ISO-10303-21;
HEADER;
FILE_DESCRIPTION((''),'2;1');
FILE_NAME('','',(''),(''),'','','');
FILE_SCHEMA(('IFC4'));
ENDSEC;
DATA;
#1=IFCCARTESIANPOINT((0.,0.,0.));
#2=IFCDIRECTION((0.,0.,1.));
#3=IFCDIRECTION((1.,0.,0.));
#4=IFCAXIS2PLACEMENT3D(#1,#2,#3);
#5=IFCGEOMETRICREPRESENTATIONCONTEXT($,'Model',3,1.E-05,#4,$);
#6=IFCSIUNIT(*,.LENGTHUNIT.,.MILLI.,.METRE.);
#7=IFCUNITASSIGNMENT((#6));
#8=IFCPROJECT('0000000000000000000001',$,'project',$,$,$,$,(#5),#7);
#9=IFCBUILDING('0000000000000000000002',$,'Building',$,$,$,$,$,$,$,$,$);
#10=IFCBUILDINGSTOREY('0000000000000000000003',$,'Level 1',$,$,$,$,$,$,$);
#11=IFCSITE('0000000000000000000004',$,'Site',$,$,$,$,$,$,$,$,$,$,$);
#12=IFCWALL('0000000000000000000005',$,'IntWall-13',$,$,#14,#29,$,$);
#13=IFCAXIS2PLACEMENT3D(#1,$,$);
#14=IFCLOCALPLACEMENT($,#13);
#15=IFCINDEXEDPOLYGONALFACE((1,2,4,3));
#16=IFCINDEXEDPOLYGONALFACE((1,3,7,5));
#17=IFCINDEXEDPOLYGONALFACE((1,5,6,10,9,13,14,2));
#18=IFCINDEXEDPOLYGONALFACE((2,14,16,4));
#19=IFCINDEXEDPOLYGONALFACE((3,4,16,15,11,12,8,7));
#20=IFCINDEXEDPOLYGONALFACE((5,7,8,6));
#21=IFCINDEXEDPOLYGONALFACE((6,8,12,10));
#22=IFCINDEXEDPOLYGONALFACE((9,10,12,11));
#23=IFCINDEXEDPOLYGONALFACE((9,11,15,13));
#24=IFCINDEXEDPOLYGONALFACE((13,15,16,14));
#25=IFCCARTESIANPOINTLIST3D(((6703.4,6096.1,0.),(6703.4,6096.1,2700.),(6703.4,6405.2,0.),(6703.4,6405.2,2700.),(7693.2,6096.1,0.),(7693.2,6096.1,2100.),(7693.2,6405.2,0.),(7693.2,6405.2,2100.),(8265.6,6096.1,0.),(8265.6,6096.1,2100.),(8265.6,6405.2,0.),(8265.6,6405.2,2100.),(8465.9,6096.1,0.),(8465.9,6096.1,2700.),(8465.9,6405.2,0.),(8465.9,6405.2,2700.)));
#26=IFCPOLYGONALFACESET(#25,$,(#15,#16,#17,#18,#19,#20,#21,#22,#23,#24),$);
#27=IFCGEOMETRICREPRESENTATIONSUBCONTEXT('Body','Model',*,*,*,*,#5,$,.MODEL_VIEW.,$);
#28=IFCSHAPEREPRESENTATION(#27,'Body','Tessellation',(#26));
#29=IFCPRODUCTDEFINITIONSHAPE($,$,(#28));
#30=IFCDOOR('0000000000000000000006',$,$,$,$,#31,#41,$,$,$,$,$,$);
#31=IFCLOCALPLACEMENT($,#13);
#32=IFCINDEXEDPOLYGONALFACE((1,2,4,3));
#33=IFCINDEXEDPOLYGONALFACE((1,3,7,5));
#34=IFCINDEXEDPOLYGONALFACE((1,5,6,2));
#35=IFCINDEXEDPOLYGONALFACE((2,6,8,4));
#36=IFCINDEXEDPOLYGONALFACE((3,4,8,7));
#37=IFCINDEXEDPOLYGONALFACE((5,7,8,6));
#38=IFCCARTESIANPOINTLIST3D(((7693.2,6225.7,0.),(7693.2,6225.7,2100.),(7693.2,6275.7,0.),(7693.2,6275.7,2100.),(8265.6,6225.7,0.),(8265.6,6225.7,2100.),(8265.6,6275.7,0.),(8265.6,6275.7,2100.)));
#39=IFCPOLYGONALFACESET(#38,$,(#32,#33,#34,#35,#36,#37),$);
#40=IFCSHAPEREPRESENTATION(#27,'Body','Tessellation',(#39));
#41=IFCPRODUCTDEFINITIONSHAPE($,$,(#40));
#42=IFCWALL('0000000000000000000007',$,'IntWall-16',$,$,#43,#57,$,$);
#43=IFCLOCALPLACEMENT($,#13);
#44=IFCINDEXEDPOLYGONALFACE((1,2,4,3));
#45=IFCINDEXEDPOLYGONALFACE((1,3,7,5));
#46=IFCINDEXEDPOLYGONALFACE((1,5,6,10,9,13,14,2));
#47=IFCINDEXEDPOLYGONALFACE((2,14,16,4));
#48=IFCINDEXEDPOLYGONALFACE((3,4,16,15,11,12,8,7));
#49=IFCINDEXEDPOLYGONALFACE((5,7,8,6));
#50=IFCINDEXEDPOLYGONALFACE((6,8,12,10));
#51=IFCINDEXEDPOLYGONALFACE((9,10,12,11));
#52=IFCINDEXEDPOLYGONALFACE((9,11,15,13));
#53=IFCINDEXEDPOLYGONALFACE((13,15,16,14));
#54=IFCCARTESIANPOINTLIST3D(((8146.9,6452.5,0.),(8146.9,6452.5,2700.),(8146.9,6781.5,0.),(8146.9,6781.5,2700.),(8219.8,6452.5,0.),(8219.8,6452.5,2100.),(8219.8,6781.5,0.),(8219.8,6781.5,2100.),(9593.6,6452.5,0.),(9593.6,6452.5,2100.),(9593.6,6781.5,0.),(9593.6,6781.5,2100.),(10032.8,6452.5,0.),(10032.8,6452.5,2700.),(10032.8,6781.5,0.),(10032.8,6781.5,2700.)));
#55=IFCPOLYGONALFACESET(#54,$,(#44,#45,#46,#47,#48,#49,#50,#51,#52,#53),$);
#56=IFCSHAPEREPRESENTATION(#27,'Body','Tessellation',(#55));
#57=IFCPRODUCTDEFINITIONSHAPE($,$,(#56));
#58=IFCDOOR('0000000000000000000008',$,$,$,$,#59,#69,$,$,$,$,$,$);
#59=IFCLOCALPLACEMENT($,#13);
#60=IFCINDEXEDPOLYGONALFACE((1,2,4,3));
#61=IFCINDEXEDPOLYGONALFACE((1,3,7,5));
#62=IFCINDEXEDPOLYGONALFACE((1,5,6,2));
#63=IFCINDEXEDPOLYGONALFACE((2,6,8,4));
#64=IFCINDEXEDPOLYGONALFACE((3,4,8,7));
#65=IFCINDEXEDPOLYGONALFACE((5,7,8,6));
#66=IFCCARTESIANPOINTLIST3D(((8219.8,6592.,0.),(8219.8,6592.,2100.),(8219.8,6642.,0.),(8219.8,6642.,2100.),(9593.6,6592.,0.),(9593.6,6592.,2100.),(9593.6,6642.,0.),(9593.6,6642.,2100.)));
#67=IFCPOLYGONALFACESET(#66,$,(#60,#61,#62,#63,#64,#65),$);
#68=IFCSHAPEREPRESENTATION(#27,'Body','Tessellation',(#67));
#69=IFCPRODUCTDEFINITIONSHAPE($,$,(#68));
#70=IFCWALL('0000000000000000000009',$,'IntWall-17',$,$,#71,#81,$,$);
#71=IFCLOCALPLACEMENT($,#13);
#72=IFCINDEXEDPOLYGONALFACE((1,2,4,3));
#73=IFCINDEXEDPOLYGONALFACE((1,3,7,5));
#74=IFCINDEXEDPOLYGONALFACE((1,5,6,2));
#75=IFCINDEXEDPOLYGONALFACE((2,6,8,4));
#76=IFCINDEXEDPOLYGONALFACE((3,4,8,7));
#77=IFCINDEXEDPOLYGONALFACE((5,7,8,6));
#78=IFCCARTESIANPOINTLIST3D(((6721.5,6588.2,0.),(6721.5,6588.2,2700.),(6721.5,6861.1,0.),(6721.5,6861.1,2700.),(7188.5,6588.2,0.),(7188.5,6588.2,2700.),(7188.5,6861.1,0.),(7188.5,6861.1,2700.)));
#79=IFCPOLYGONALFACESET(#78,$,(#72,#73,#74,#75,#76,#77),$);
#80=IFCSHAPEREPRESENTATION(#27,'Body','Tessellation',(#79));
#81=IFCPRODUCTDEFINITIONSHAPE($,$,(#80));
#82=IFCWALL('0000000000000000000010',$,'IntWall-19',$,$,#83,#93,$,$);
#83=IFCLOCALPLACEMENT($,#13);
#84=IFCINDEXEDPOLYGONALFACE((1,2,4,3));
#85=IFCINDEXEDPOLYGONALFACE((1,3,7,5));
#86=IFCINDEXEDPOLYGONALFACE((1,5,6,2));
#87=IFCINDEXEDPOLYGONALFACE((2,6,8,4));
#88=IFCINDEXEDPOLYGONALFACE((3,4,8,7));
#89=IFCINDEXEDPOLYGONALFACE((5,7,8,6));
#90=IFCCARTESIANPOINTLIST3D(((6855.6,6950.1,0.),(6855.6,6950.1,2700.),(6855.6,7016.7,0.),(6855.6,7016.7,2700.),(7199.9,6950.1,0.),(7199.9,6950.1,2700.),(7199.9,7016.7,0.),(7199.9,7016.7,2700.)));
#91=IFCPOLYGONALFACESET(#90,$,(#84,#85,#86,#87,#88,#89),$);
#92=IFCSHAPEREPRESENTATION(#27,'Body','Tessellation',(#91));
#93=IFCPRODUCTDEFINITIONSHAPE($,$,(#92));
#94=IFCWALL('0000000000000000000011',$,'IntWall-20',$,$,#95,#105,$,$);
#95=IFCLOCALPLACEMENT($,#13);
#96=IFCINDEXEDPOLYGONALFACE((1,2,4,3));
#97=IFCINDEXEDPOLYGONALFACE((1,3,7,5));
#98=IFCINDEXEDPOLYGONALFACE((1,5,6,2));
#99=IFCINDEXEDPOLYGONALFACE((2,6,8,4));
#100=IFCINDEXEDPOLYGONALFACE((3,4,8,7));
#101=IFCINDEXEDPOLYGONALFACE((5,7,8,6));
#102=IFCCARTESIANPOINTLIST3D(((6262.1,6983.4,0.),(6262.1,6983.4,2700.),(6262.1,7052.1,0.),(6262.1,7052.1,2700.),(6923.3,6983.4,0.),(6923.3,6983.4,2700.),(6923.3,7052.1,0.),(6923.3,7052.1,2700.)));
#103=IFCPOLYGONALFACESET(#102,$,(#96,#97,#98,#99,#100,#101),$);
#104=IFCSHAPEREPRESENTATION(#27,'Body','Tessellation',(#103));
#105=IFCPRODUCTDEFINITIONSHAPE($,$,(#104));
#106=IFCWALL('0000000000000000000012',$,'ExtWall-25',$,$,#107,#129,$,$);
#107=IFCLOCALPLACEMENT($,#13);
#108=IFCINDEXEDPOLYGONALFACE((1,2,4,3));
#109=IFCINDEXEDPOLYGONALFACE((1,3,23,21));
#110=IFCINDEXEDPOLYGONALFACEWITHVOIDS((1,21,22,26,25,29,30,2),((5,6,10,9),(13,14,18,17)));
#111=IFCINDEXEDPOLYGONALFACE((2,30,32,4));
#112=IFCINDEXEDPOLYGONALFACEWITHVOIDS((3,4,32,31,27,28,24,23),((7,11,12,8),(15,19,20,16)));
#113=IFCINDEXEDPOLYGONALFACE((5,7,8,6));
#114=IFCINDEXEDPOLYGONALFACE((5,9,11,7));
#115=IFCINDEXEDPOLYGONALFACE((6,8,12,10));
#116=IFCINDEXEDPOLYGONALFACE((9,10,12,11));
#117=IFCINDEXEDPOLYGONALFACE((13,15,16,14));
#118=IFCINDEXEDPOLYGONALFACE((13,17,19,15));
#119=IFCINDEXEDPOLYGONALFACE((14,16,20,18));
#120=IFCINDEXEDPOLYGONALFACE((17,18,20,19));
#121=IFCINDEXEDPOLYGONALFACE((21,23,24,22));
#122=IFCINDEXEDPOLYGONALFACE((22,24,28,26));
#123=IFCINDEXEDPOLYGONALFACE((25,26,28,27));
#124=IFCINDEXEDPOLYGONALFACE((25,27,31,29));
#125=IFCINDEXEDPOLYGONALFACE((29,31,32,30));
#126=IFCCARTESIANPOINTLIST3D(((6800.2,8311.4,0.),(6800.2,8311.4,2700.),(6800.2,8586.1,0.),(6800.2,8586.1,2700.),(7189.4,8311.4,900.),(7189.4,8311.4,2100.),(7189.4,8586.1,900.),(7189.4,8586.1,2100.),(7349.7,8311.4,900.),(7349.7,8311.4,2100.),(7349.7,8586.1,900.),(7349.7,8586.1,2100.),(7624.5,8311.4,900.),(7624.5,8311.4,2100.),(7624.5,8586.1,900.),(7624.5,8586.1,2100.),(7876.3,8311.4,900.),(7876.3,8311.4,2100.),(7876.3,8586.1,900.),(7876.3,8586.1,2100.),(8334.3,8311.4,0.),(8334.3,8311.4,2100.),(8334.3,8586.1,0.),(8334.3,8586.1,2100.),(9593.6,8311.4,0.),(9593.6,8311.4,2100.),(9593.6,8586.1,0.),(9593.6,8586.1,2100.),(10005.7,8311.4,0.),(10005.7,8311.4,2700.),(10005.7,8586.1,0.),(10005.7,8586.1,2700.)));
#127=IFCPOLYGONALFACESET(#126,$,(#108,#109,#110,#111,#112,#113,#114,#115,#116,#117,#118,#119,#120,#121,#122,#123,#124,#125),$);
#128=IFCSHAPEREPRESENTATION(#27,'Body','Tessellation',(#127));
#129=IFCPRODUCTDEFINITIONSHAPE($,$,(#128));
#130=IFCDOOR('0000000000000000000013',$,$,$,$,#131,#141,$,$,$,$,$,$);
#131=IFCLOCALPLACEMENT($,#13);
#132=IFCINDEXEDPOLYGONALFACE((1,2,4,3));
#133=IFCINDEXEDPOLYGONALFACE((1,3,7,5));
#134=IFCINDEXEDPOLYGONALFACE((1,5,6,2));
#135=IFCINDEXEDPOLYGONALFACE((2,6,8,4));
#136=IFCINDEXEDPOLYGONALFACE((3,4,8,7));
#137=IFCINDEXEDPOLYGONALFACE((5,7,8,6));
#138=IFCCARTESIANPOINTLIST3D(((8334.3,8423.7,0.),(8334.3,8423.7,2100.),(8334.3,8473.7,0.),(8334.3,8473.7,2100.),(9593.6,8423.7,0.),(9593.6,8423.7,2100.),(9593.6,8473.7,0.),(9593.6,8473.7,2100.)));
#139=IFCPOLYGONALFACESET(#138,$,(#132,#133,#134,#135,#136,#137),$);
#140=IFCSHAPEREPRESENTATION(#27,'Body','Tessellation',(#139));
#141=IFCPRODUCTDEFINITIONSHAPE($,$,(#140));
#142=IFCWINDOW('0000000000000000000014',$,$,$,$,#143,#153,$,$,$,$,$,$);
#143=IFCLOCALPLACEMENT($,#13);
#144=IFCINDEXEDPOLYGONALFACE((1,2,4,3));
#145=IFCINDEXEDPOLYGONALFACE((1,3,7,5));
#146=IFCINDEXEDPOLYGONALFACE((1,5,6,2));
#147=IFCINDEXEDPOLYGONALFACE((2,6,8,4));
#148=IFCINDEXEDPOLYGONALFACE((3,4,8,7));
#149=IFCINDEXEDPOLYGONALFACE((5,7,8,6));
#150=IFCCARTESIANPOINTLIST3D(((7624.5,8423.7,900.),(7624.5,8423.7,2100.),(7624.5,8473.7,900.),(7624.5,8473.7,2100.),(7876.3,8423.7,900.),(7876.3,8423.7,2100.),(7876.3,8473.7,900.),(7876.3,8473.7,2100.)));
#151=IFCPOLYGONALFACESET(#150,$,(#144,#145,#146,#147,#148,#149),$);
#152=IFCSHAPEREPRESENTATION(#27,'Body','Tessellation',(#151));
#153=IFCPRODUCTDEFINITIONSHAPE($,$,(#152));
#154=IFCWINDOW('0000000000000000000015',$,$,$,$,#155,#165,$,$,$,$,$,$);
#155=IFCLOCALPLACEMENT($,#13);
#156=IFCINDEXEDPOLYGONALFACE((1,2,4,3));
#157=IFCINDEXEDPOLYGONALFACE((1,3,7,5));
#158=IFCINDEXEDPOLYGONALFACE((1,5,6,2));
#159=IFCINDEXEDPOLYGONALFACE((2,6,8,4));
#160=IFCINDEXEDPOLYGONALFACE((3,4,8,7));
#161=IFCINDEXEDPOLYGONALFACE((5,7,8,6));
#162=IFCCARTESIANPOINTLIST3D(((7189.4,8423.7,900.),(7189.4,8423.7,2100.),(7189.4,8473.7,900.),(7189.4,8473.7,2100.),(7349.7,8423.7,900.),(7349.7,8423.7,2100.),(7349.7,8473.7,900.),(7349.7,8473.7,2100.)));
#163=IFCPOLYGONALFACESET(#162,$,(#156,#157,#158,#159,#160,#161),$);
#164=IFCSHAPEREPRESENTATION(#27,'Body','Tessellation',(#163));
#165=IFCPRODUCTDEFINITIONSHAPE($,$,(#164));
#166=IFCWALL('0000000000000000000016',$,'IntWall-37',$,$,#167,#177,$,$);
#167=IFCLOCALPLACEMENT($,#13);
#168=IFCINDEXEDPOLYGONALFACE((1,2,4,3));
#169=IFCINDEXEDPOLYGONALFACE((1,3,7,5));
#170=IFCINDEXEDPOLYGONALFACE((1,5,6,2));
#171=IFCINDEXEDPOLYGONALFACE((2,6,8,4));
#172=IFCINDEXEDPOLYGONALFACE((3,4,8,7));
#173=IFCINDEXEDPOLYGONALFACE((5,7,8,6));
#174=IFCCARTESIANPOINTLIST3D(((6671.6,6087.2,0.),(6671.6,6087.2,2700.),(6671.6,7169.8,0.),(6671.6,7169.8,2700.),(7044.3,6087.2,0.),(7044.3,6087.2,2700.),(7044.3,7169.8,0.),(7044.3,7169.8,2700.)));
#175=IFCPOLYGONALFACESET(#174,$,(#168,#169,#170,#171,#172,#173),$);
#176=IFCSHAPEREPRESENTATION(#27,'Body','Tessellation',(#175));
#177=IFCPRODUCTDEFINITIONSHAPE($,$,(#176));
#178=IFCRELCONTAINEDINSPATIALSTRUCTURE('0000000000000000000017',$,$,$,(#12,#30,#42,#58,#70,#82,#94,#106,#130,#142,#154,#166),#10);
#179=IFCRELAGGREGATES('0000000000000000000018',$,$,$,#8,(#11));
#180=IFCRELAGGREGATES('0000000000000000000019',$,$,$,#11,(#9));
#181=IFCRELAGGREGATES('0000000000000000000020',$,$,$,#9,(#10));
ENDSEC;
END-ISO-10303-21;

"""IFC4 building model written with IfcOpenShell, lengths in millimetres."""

from ifc_helpers import new_model, si_unit, frame, origin_with_axes, place, context, subcontext, project, spatial, indexed_curve, outline, extrude, element, fill, save


model = new_model("IFC4")

# Units and contexts
model_context = context("Model", 3, precision=1e-05, world=origin_with_axes())
body_context = subcontext(model_context, "Body", "Model", "MODEL_VIEW")
ifc_project = project(units=[si_unit("LENGTHUNIT", "METRE", prefix="MILLI")], contexts=[model_context])

# Site, building, storey
site = spatial("IfcSite", under=ifc_project, Name="Site")
building = spatial("IfcBuilding", under=site, Name="Building")
storey = spatial("IfcBuildingStorey", under=building, Name="Level 1")

# Walls, openings, doors
wall_1_placement = place(None, frame((6703.4, 6250.7, 0.0), z_axis=(0.0, 0.0, 1.0), x_axis=(1.0, 0.0, 0.0)))
wall_1 = element("IfcWall", 1, at=wall_1_placement, inside=storey, Name="IntWall-13", context=body_context, shape_type="SweptSolid", body=[
    extrude(outline(indexed_curve([(0.0, 0.0), (0.0, 309.1), (1762.5, 309.1), (1762.5, 0.0), (0.0, 0.0)], self_intersect=False)), frame((0.0, -154.6, 0.0), z_axis=(0.0, 0.0, 1.0), x_axis=(1.0, 0.0, 0.0)), (0.0, 0.0, 1.0), 2700.0),
])
opening_1_placement = place(wall_1_placement, frame((989.8, 0.0, 0.0), z_axis=(0.0, 0.0, 1.0), x_axis=(1.0, 0.0, 0.0)))
opening_1 = element("IfcOpeningElement", 2, at=opening_1_placement, cuts=wall_1, context=body_context, shape_type="SweptSolid", body=[
    extrude(outline(indexed_curve([(0.0, 0.0), (0.0, 409.1), (572.4, 409.1), (572.4, 0.0), (0.0, 0.0)], self_intersect=False)), frame((0.0, -204.6, 0.0), z_axis=(0.0, 0.0, 1.0), x_axis=(1.0, 0.0, 0.0)), (0.0, 0.0, 1.0), 2100.0),
])
door_1_placement = place(opening_1_placement, origin_with_axes())
door_1 = element("IfcDoor", 3, at=door_1_placement, inside=storey, context=body_context, shape_type="SweptSolid", body=[
    extrude(outline(indexed_curve([(0.0, 0.0), (0.0, 50.0), (572.4, 50.0), (572.4, 0.0), (0.0, 0.0)], self_intersect=False)), frame((0.0, -25.0, 0.0), z_axis=(0.0, 0.0, 1.0), x_axis=(1.0, 0.0, 0.0)), (0.0, 0.0, 1.0), 2100.0),
])
fill(opening_1, door_1)
wall_2_placement = place(None, frame((8146.9, 6617.0, 0.0), z_axis=(0.0, 0.0, 1.0), x_axis=(1.0, 0.0, 0.0)))
wall_2 = element("IfcWall", 4, at=wall_2_placement, inside=storey, Name="IntWall-16", context=body_context, shape_type="SweptSolid", body=[
    extrude(outline(indexed_curve([(0.0, 0.0), (0.0, 329.0), (1886.0, 329.0), (1886.0, 0.0), (0.0, 0.0)], self_intersect=False)), frame((0.0, -164.5, 0.0), z_axis=(0.0, 0.0, 1.0), x_axis=(1.0, 0.0, 0.0)), (0.0, 0.0, 1.0), 2700.0),
])
opening_2_placement = place(wall_2_placement, frame((72.9, 0.0, 0.0), z_axis=(0.0, 0.0, 1.0), x_axis=(1.0, 0.0, 0.0)))
opening_2 = element("IfcOpeningElement", 5, at=opening_2_placement, cuts=wall_2, context=body_context, shape_type="SweptSolid", body=[
    extrude(outline(indexed_curve([(0.0, 0.0), (0.0, 429.0), (1373.8, 429.0), (1373.8, 0.0), (0.0, 0.0)], self_intersect=False)), frame((0.0, -214.5, 0.0), z_axis=(0.0, 0.0, 1.0), x_axis=(1.0, 0.0, 0.0)), (0.0, 0.0, 1.0), 2100.0),
])
door_2_placement = place(opening_2_placement, origin_with_axes())
door_2 = element("IfcDoor", 6, at=door_2_placement, inside=storey, context=body_context, shape_type="SweptSolid", body=[
    extrude(outline(indexed_curve([(0.0, 0.0), (0.0, 50.0), (1373.8, 50.0), (1373.8, 0.0), (0.0, 0.0)], self_intersect=False)), frame((0.0, -25.0, 0.0), z_axis=(0.0, 0.0, 1.0), x_axis=(1.0, 0.0, 0.0)), (0.0, 0.0, 1.0), 2100.0),
])
fill(opening_2, door_2)

# Walls
wall_3_placement = place(None, frame((6721.5, 6724.6, 0.0), z_axis=(0.0, 0.0, 1.0), x_axis=(1.0, 0.0, 0.0)))
element("IfcWall", 7, at=wall_3_placement, inside=storey, Name="IntWall-17", context=body_context, shape_type="SweptSolid", body=[
    extrude(outline(indexed_curve([(0.0, 0.0), (0.0, 272.9), (467.0, 272.9), (467.0, 0.0), (0.0, 0.0)], self_intersect=False)), frame((0.0, -136.5, 0.0), z_axis=(0.0, 0.0, 1.0), x_axis=(1.0, 0.0, 0.0)), (0.0, 0.0, 1.0), 2700.0),
])
wall_4_placement = place(None, frame((6855.6, 6983.4, 0.0), z_axis=(0.0, 0.0, 1.0), x_axis=(1.0, 0.0, 0.0)))
element("IfcWall", 8, at=wall_4_placement, inside=storey, Name="IntWall-19", context=body_context, shape_type="SweptSolid", body=[
    extrude(outline(indexed_curve([(0.0, 0.0), (0.0, 66.6), (344.2, 66.6), (344.2, 0.0), (0.0, 0.0)], self_intersect=False)), frame((0.0, -33.3, 0.0), z_axis=(0.0, 0.0, 1.0), x_axis=(1.0, 0.0, 0.0)), (0.0, 0.0, 1.0), 2700.0),
])
wall_5_placement = place(None, frame((6262.1, 7017.7, 0.0), z_axis=(0.0, 0.0, 1.0), x_axis=(1.0, 0.0, 0.0)))
element("IfcWall", 9, at=wall_5_placement, inside=storey, Name="IntWall-20", context=body_context, shape_type="SweptSolid", body=[
    extrude(outline(indexed_curve([(0.0, 0.0), (0.0, 68.7), (661.1, 68.7), (661.1, 0.0), (0.0, 0.0)], self_intersect=False)), frame((0.0, -34.3, 0.0), z_axis=(0.0, 0.0, 1.0), x_axis=(1.0, 0.0, 0.0)), (0.0, 0.0, 1.0), 2700.0),
])

# Wall, openings, door, windows
wall_6_placement = place(None, frame((6800.2, 8448.7, 0.0), z_axis=(0.0, 0.0, 1.0), x_axis=(1.0, 0.0, 0.0)))
wall_6 = element("IfcWall", 10, at=wall_6_placement, inside=storey, Name="ExtWall-25", context=body_context, shape_type="SweptSolid", body=[
    extrude(outline(indexed_curve([(0.0, 0.0), (0.0, 274.8), (3205.5, 274.8), (3205.5, 0.0), (0.0, 0.0)], self_intersect=False)), frame((0.0, -137.4, 0.0), z_axis=(0.0, 0.0, 1.0), x_axis=(1.0, 0.0, 0.0)), (0.0, 0.0, 1.0), 2700.0),
])
opening_3_placement = place(wall_6_placement, frame((1534.1, 0.0, 0.0), z_axis=(0.0, 0.0, 1.0), x_axis=(1.0, 0.0, 0.0)))
opening_3 = element("IfcOpeningElement", 11, at=opening_3_placement, cuts=wall_6, context=body_context, shape_type="SweptSolid", body=[
    extrude(outline(indexed_curve([(0.0, 0.0), (0.0, 374.8), (1259.3, 374.8), (1259.3, 0.0), (0.0, 0.0)], self_intersect=False)), frame((0.0, -187.4, 0.0), z_axis=(0.0, 0.0, 1.0), x_axis=(1.0, 0.0, 0.0)), (0.0, 0.0, 1.0), 2100.0),
])
opening_4_placement = place(wall_6_placement, frame((824.3, 0.0, 900.0), z_axis=(0.0, 0.0, 1.0), x_axis=(1.0, 0.0, 0.0)))
opening_4 = element("IfcOpeningElement", 12, at=opening_4_placement, cuts=wall_6, context=body_context, shape_type="SweptSolid", body=[
    extrude(outline(indexed_curve([(0.0, 0.0), (0.0, 374.8), (251.9, 374.8), (251.9, 0.0), (0.0, 0.0)], self_intersect=False)), frame((0.0, -187.4, 0.0), z_axis=(0.0, 0.0, 1.0), x_axis=(1.0, 0.0, 0.0)), (0.0, 0.0, 1.0), 1200.0),
])
opening_5_placement = place(wall_6_placement, frame((389.2, 0.0, 900.0), z_axis=(0.0, 0.0, 1.0), x_axis=(1.0, 0.0, 0.0)))
opening_5 = element("IfcOpeningElement", 13, at=opening_5_placement, cuts=wall_6, context=body_context, shape_type="SweptSolid", body=[
    extrude(outline(indexed_curve([(0.0, 0.0), (0.0, 374.8), (160.3, 374.8), (160.3, 0.0), (0.0, 0.0)], self_intersect=False)), frame((0.0, -187.4, 0.0), z_axis=(0.0, 0.0, 1.0), x_axis=(1.0, 0.0, 0.0)), (0.0, 0.0, 1.0), 1200.0),
])
door_3_placement = place(opening_3_placement, origin_with_axes())
door_3 = element("IfcDoor", 14, at=door_3_placement, inside=storey, context=body_context, shape_type="SweptSolid", body=[
    extrude(outline(indexed_curve([(0.0, 0.0), (0.0, 50.0), (1259.3, 50.0), (1259.3, 0.0), (0.0, 0.0)], self_intersect=False)), frame((0.0, -25.0, 0.0), z_axis=(0.0, 0.0, 1.0), x_axis=(1.0, 0.0, 0.0)), (0.0, 0.0, 1.0), 2100.0),
])
fill(opening_3, door_3)
window_1_placement = place(opening_4_placement, origin_with_axes())
window_1 = element("IfcWindow", 15, at=window_1_placement, inside=storey, context=body_context, shape_type="SweptSolid", body=[
    extrude(outline(indexed_curve([(0.0, 0.0), (0.0, 50.0), (251.9, 50.0), (251.9, 0.0), (0.0, 0.0)], self_intersect=False)), frame((0.0, -25.0, 0.0), z_axis=(0.0, 0.0, 1.0), x_axis=(1.0, 0.0, 0.0)), (0.0, 0.0, 1.0), 1200.0),
])
fill(opening_4, window_1)
window_2_placement = place(opening_5_placement, frame((0.0, 0.0, 0.0), z_axis=(0.0, 0.0, 1.0), x_axis=(1.0, 0.0, 0.0)))
window_2 = element("IfcWindow", 16, at=window_2_placement, inside=storey, context=body_context, shape_type="SweptSolid", body=[
    extrude(outline(indexed_curve([(0.0, 0.0), (0.0, 50.0), (160.3, 50.0), (160.3, 0.0), (0.0, 0.0)], self_intersect=False)), frame((0.0, -25.0, 0.0), z_axis=(0.0, 0.0, 1.0), x_axis=(1.0, 0.0, 0.0)), (0.0, 0.0, 1.0), 1200.0),
])
fill(opening_5, window_2)

# Wall
wall_7_placement = place(None, frame((6857.9, 6087.2, 0.0), z_axis=(0.0, 0.0, 1.0), x_axis=(0.0, 1.0, 0.0)))
element("IfcWall", 17, at=wall_7_placement, inside=storey, Name="IntWall-37", context=body_context, shape_type="SweptSolid", body=[
    extrude(outline(indexed_curve([(0.0, 0.0), (0.0, 372.8), (1082.5, 372.8), (1082.5, 0.0), (0.0, 0.0)], self_intersect=False)), frame((0.0, -186.4, 0.0), z_axis=(0.0, 0.0, 1.0), x_axis=(1.0, 0.0, 0.0)), (0.0, 0.0, 1.0), 2700.0),
])

save(model, "model.ifc")
